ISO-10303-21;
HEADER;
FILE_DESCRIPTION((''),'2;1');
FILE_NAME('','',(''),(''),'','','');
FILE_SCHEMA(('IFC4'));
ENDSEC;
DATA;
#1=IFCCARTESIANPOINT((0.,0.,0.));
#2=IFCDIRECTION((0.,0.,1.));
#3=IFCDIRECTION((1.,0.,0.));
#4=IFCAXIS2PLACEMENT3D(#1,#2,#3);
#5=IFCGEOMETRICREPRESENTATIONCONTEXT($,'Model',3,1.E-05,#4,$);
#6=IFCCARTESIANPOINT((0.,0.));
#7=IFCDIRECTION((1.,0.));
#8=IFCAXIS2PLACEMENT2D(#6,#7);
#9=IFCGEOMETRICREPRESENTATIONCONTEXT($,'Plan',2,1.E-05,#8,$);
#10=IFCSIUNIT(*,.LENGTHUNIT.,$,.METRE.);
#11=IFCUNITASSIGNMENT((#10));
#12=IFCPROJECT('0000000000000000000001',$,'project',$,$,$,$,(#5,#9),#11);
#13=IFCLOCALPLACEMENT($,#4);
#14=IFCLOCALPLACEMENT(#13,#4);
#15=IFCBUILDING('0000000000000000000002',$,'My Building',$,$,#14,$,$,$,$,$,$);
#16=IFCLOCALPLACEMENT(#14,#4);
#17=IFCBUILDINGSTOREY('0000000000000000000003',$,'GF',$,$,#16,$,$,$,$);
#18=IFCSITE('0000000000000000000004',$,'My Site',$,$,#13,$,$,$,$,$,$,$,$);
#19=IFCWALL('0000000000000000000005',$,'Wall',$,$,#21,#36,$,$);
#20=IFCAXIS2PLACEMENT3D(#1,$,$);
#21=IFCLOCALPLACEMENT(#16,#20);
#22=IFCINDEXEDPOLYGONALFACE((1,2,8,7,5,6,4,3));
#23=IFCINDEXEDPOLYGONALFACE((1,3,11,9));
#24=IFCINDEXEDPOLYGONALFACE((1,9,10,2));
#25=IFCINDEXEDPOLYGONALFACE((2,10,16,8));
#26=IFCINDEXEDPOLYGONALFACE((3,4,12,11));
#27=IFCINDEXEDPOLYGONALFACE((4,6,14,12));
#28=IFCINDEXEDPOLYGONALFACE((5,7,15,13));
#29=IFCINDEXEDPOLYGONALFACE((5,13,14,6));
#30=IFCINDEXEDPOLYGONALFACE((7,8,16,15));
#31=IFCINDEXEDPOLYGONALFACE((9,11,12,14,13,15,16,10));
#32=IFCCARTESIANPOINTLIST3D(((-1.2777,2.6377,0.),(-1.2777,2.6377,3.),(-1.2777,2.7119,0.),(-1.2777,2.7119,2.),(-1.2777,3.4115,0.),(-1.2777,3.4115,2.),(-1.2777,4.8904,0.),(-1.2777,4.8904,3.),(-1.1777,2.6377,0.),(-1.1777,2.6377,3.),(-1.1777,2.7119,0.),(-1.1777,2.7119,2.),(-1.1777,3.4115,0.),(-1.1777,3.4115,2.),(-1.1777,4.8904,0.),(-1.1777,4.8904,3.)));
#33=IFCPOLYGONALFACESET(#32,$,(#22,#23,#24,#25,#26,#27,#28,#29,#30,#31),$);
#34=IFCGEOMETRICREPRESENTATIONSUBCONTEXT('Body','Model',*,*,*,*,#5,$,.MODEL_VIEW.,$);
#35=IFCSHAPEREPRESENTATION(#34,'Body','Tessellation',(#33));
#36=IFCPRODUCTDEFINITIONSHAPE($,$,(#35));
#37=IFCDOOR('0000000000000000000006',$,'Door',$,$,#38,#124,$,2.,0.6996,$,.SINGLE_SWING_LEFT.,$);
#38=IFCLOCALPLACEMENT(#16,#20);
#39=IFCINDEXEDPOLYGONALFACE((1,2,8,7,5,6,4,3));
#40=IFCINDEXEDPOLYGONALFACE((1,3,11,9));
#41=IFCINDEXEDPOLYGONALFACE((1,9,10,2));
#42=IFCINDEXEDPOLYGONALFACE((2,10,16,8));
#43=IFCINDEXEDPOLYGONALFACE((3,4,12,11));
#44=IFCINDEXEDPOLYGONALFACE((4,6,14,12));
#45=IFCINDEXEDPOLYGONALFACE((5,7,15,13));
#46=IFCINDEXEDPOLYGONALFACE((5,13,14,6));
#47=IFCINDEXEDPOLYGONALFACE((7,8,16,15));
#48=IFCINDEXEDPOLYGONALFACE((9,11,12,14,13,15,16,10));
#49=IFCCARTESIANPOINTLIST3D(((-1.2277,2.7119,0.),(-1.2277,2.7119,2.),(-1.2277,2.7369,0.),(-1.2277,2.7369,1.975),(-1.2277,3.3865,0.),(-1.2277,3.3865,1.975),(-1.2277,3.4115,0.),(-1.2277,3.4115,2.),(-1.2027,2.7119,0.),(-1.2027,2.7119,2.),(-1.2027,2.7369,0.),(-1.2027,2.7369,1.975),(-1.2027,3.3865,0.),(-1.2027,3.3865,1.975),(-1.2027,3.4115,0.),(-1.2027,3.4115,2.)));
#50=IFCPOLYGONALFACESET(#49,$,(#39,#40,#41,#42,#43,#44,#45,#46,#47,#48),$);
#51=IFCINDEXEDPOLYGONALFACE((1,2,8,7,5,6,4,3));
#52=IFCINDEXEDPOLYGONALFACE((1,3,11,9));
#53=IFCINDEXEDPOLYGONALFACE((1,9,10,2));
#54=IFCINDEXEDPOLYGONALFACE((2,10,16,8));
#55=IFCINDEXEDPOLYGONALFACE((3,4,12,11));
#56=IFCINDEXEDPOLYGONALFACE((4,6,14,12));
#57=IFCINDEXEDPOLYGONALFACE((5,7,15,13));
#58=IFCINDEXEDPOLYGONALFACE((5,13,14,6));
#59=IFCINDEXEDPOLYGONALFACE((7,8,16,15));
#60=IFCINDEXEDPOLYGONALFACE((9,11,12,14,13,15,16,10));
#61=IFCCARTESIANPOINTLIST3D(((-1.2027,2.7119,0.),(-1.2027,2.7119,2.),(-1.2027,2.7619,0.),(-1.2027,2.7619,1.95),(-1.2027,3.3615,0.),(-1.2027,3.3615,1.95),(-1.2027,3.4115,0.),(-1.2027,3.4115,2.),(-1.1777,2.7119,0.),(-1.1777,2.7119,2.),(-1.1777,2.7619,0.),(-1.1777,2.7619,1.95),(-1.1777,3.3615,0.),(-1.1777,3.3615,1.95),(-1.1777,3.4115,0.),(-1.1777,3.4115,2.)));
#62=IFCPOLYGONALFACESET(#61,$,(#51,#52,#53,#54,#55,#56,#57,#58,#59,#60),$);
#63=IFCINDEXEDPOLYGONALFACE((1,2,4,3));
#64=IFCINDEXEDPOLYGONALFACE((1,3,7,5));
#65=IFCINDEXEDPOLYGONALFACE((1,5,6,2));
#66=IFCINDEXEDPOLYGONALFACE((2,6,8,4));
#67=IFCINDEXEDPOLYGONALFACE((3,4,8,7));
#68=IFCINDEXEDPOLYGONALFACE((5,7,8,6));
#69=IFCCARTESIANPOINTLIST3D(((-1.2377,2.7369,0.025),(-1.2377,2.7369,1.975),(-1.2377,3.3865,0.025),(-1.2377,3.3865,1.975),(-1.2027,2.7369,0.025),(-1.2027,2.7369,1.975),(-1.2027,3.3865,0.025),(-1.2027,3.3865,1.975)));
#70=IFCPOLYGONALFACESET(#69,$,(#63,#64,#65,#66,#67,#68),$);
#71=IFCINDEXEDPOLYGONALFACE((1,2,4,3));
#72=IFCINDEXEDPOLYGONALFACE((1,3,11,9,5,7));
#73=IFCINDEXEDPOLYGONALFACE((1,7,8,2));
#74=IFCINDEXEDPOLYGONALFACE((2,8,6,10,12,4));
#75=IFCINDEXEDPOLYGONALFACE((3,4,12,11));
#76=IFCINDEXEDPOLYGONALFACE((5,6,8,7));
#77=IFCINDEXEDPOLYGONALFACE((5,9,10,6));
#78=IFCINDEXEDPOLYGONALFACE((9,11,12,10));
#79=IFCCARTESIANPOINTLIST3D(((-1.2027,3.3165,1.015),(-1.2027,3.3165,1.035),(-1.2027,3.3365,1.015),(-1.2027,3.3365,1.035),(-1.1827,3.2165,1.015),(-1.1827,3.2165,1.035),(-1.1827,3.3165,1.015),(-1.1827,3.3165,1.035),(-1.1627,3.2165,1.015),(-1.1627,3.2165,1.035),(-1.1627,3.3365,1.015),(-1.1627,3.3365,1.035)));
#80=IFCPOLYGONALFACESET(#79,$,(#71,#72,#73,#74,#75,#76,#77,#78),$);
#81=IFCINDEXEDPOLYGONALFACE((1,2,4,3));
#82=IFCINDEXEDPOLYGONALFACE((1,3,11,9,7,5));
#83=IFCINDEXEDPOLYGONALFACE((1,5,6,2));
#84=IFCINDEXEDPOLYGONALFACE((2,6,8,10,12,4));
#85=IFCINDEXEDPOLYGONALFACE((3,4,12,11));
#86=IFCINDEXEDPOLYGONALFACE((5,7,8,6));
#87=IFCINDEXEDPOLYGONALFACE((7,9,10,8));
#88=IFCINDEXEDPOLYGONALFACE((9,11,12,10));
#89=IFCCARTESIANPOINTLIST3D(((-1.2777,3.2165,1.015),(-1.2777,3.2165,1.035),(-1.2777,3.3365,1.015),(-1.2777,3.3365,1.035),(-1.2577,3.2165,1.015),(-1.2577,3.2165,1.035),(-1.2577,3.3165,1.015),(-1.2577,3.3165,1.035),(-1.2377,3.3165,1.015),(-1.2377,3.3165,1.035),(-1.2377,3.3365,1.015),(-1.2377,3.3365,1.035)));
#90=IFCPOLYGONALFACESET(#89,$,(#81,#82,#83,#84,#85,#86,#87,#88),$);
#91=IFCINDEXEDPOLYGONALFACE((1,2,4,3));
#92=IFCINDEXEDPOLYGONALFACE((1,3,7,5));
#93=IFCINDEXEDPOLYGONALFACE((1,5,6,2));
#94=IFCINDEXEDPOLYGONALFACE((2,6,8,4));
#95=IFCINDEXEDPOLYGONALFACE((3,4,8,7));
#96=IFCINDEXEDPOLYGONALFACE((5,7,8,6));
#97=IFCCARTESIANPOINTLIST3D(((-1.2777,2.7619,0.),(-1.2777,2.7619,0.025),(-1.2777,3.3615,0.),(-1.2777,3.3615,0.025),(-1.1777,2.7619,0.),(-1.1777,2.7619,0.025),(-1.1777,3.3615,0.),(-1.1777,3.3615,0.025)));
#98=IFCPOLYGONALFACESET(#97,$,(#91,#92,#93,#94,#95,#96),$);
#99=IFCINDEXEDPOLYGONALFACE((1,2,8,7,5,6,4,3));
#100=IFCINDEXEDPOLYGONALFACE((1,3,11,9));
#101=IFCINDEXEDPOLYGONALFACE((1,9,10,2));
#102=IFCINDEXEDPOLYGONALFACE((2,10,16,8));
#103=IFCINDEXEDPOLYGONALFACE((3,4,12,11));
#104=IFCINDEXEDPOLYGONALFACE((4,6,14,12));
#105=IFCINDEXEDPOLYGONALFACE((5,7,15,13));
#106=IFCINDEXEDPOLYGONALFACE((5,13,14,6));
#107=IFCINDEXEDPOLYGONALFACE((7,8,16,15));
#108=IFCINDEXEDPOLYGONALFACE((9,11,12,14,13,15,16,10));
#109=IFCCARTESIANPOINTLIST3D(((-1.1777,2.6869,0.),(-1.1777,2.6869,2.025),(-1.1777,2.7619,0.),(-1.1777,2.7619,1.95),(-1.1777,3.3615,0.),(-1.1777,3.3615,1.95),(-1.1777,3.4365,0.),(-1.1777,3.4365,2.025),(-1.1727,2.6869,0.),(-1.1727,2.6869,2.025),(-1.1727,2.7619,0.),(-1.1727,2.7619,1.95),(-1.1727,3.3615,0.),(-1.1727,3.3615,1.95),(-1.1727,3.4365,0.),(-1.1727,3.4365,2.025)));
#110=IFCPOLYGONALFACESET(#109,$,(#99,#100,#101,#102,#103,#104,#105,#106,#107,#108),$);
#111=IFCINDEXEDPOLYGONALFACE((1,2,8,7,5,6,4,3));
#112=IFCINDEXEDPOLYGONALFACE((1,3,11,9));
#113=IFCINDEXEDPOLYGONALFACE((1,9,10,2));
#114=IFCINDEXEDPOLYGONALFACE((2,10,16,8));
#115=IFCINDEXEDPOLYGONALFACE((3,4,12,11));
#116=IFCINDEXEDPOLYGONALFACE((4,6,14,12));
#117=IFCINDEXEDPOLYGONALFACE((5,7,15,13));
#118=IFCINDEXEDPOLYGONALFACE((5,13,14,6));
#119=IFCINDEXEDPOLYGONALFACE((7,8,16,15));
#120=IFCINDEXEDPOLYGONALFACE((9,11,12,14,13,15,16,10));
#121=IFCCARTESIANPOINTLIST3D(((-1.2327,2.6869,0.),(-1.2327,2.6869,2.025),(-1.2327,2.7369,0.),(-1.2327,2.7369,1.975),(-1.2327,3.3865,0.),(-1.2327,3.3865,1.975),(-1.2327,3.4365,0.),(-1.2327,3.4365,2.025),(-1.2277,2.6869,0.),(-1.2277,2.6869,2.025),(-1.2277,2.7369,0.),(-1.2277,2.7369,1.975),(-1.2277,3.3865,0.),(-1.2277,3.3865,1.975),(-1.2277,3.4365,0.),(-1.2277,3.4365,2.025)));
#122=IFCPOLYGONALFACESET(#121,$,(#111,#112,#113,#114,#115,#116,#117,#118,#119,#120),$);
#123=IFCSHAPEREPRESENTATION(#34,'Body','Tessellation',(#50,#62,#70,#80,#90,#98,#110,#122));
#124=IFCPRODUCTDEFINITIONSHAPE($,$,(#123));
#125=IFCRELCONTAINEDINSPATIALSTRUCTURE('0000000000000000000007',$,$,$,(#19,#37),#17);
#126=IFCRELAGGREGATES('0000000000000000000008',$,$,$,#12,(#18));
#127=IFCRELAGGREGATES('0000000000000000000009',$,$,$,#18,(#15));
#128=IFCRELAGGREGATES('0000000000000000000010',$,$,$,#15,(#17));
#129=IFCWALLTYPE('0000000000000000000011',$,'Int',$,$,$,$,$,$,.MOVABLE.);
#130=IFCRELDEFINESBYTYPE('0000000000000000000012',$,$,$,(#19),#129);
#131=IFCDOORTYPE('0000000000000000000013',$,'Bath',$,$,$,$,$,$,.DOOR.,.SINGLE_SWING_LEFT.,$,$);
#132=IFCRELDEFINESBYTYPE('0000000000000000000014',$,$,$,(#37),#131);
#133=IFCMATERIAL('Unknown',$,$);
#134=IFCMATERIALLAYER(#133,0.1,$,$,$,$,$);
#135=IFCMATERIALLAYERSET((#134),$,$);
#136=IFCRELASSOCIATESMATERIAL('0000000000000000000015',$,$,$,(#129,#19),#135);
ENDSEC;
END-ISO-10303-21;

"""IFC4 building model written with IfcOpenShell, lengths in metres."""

from ifc_helpers import new_model, entity, si_unit, frame, origin_with_axes, origin_2d_with_axis, place, context, subcontext, project, spatial, line, indexed_curve, outline, extrude, shape, source, transform, mapped, material, layer, layer_set, layer_usage, type_object, type_shapes, element, fill, save


model = new_model("IFC4")

# Units and contexts
model_context = context("Model", 3, precision=1e-05, world=origin_with_axes())
plan_context = context("Plan", 2, precision=1e-05, world=origin_2d_with_axis())
body_context_1 = subcontext(model_context, "Body", "Model", "MODEL_VIEW")
body_context_2 = subcontext(plan_context, "Body", "Plan", "PLAN_VIEW")
ifc_project = project(units=[si_unit("LENGTHUNIT", "METRE")], contexts=[model_context, plan_context])

# Site, building, storey
site_placement = place(None, origin_with_axes())
site = spatial("IfcSite", under=ifc_project, at=site_placement, Name="My Site")
building_placement = place(site_placement, origin_with_axes())
building = spatial("IfcBuilding", under=site, at=building_placement, Name="My Building")
storey_placement = place(building_placement, origin_with_axes())
storey = spatial("IfcBuildingStorey", under=building, at=storey_placement, Name="GF")

# Shared definitions
ifc_material = material(Name="Unknown")

# Shared definitions
ifc_layer_1 = layer(ifc_material, 0.1)
ifc_layer_set_1 = layer_set([ifc_layer_1])
wall_type_1 = type_object("IfcWallType", Name="Int", PredefinedType="MOVABLE", material=ifc_layer_set_1)

# Wall, opening, door
ifc_layer_usage_1 = layer_usage(ifc_layer_set_1, "AXIS2", "POSITIVE", 0.0)
wall_1_placement = place(storey_placement, frame((-1.2777, 4.8904, 0.0), z_axis=(0.0, 0.0, 1.0), x_axis=(0.0, -1.0, 0.0)))
wall_1 = element("IfcWall", 1, at=wall_1_placement, inside=storey, type_object=wall_type_1, material=ifc_layer_usage_1, Name="Wall", context=body_context_1, shape_type="SweptSolid", body=[
    extrude(outline(indexed_curve([(0.0, 0.0), (0.0, 0.1), (2.2527, 0.1), (2.2527, 0.0)], segments=[line(1, 2, 3, 4, 1)])), origin_with_axes(), (0.0, 0.0, 1.0), 3.0),
])
shared_shape_1 = source(origin_with_axes(), body_context_1, "Body", "SweptSolid", [
    extrude(outline(indexed_curve([(0.0, 0.0), (0.6996, 0.0), (0.6996, 2.0), (0.0, 2.0)], segments=[line(1, 2, 3, 4, 1)])), frame((0.0, -0.6, 0.0), z_axis=(0.0, -1.0, 0.0), x_axis=(1.0, 0.0, 0.0)), (0.0, 0.0, -1.0), 1.2),
])
opening_1_placement = place(wall_1_placement, frame((2.1785, 0.1, 0.0), z_axis=(0.0, 0.0, 1.0), x_axis=(-1.0, 0.0, 0.0)))
opening_1 = element("IfcOpeningElement", 2, at=opening_1_placement, cuts=wall_1, PredefinedType="OPENING", context=body_context_1, shape_type="MappedRepresentation", body=[
    mapped(shared_shape_1, transform((0.0, 0.0, 0.0), x_axis=(1.0, 0.0, 0.0), y_axis=(0.0, 1.0, 0.0), z_axis=(0.0, 0.0, 1.0), scale=1.0)),
])
door_type_1 = type_object("IfcDoorType", Name="Bath", OperationType="SINGLE_SWING_LEFT", PredefinedType="DOOR")
shared_shape_2 = source(origin_with_axes(), body_context_1, "Body", "SweptSolid", [
    extrude(outline(indexed_curve([(0.025, 0.0), (0.025, 1.975), (0.6746, 1.975), (0.6746, 0.0), (0.6996, 0.0), (0.6996, 2.0), (0.0, 2.0), (0.0, 0.0), (0.025, 0.0)])), frame((0.0, 0.025, 0.0), z_axis=(0.0, -1.0, 0.0), x_axis=(1.0, 0.0, 0.0)), (0.0, 0.0, -1.0), 0.025),
    extrude(outline(indexed_curve([(0.0, 0.0), (0.0, 2.0), (0.6996, 2.0), (0.6996, 0.0), (0.6496, 0.0), (0.6496, 1.95), (0.05, 1.95), (0.05, 0.0)], segments=[line(1, 2, 3, 4, 5, 6, 7, 8, 1)])), frame((0.0, 0.0, 0.0), z_axis=(0.0, -1.0, 0.0), x_axis=(1.0, 0.0, 0.0)), (0.0, 0.0, -1.0), 0.025),
    extrude(outline(indexed_curve([(0.0, 0.0), (0.6496, 0.0), (0.6496, 0.035), (0.0, 0.035)], segments=[line(1, 2, 3, 4, 1)])), frame((0.025, 0.025, 0.025), z_axis=(0.0, 0.0, 1.0), x_axis=(1.0, 0.0, 0.0)), (0.0, 0.0, 1.0), 1.95),
    extrude(outline(indexed_curve([(0.0, 0.0), (0.0, -0.04), (-0.12, -0.04), (-0.12, -0.02), (-0.02, -0.02), (-0.02, 0.0)], segments=[line(1, 2, 3, 4, 5, 6, 1)])), frame((0.6246, 0.025, 1.015), z_axis=(0.0, 0.0, 1.0), x_axis=(1.0, 0.0, 0.0)), (0.0, 0.0, 1.0), 0.02),
    extrude(outline(indexed_curve([(0.0, 0.0), (0.0, 0.04), (-0.12, 0.04), (-0.12, 0.02), (-0.02, 0.02), (-0.02, 0.0)], segments=[line(1, 2, 3, 4, 5, 6, 1)])), frame((0.6246, 0.06, 1.015), z_axis=(0.0, 0.0, 1.0), x_axis=(1.0, 0.0, 0.0)), (0.0, 0.0, 1.0), 0.02),
    extrude(outline(indexed_curve([(0.0, 0.0), (0.5996, 0.0), (0.5996, 0.1), (0.0, 0.1)], segments=[line(1, 2, 3, 4, 1)])), frame((0.05, 0.0, 0.0), z_axis=(0.0, 0.0, 1.0), x_axis=(1.0, 0.0, 0.0)), (0.0, 0.0, 1.0), 0.025),
    extrude(outline(indexed_curve([(0.0, 0.0), (0.0, 2.025), (0.7496, 2.025), (0.7496, 0.0), (0.6746, 0.0), (0.6746, 1.95), (0.075, 1.95), (0.075, 0.0)], segments=[line(1, 2, 3, 4, 5, 6, 7, 8, 1)])), frame((-0.025, -0.005, 0.0), z_axis=(0.0, -1.0, 0.0), x_axis=(1.0, 0.0, 0.0)), (0.0, 0.0, -1.0), 0.005),
    extrude(outline(indexed_curve([(0.0, 0.0), (0.0, 2.025), (0.7496, 2.025), (0.7496, 0.0), (0.6996, 0.0), (0.6996, 1.975), (0.05, 1.975), (0.05, 0.0)], segments=[line(1, 2, 3, 4, 5, 6, 7, 8, 1)])), frame((-0.025, 0.05, 0.0), z_axis=(0.0, -1.0, 0.0), x_axis=(1.0, 0.0, 0.0)), (0.0, 0.0, -1.0), 0.005),
])
shared_shape_3 = source(origin_with_axes(), body_context_2, "Body", "Curve2D", [
    entity("IfcIndexedPolyCurve", entity("IfcCartesianPointList2D", [[0.0, 0.0], [0.0, 0.05], [0.025, 0.05], [0.025, 0.025], [0.05, 0.025], [0.05, 0.0]]), [entity("IfcLineIndex", [1, 2, 3, 4, 5, 6, 1])]),
    entity("IfcIndexedPolyCurve", entity("IfcCartesianPointList2D", [[0.6996, 0.0], [0.6996, 0.05], [0.6746, 0.05], [0.6746, 0.025], [0.6496, 0.025], [0.6496, 0.0]]), [entity("IfcLineIndex", [1, 2, 3, 4, 5, 6, 1])]),
    entity("IfcTrimmedCurve", entity("IfcEllipse", entity("IfcAxis2Placement2D", entity("IfcCartesianPoint", [0.06, 0.05]), entity("IfcDirection", [1.0, 0.0])), 0.6146, 0.6496), [entity("IfcCartesianPoint", [0.6746, 0.05])], [entity("IfcCartesianPoint", [0.06, 0.6996])], True, "CARTESIAN"),
    entity("IfcIndexedPolyCurve", entity("IfcCartesianPointList2D", [[0.025, 0.05], [0.06, 0.05], [0.06, 0.6996], [0.025, 0.6996]]), [entity("IfcLineIndex", [1, 2, 3, 4, 1])]),
])
type_shapes(door_type_1, [shared_shape_2, shared_shape_3])
door_1_placement = place(opening_1_placement, frame((0.0, 0.0, 0.0), z_axis=(0.0, 0.0, 1.0), x_axis=(1.0, 0.0, 0.0)))
door_1 = element("IfcDoor", 3, at=door_1_placement, inside=storey, type_object=door_type_1, Name="Door", OperationType="SINGLE_SWING_LEFT", OverallHeight=2.0, OverallWidth=0.6996, shapes=[
    shape(body_context_1, "Body", "MappedRepresentation", [mapped(shared_shape_2, transform((0.0, 0.0, 0.0), x_axis=(1.0, 0.0, 0.0), y_axis=(0.0, 1.0, 0.0), z_axis=(0.0, 0.0, 1.0), scale=1.0))]),
    shape(body_context_2, "Body", "MappedRepresentation", [mapped(shared_shape_3, transform((0.0, 0.0, 0.0), x_axis=(1.0, 0.0, 0.0), y_axis=(0.0, 1.0, 0.0), z_axis=(0.0, 0.0, 1.0), scale=1.0))]),
])
fill(opening_1, door_1)

save(model, "model.ifc")
